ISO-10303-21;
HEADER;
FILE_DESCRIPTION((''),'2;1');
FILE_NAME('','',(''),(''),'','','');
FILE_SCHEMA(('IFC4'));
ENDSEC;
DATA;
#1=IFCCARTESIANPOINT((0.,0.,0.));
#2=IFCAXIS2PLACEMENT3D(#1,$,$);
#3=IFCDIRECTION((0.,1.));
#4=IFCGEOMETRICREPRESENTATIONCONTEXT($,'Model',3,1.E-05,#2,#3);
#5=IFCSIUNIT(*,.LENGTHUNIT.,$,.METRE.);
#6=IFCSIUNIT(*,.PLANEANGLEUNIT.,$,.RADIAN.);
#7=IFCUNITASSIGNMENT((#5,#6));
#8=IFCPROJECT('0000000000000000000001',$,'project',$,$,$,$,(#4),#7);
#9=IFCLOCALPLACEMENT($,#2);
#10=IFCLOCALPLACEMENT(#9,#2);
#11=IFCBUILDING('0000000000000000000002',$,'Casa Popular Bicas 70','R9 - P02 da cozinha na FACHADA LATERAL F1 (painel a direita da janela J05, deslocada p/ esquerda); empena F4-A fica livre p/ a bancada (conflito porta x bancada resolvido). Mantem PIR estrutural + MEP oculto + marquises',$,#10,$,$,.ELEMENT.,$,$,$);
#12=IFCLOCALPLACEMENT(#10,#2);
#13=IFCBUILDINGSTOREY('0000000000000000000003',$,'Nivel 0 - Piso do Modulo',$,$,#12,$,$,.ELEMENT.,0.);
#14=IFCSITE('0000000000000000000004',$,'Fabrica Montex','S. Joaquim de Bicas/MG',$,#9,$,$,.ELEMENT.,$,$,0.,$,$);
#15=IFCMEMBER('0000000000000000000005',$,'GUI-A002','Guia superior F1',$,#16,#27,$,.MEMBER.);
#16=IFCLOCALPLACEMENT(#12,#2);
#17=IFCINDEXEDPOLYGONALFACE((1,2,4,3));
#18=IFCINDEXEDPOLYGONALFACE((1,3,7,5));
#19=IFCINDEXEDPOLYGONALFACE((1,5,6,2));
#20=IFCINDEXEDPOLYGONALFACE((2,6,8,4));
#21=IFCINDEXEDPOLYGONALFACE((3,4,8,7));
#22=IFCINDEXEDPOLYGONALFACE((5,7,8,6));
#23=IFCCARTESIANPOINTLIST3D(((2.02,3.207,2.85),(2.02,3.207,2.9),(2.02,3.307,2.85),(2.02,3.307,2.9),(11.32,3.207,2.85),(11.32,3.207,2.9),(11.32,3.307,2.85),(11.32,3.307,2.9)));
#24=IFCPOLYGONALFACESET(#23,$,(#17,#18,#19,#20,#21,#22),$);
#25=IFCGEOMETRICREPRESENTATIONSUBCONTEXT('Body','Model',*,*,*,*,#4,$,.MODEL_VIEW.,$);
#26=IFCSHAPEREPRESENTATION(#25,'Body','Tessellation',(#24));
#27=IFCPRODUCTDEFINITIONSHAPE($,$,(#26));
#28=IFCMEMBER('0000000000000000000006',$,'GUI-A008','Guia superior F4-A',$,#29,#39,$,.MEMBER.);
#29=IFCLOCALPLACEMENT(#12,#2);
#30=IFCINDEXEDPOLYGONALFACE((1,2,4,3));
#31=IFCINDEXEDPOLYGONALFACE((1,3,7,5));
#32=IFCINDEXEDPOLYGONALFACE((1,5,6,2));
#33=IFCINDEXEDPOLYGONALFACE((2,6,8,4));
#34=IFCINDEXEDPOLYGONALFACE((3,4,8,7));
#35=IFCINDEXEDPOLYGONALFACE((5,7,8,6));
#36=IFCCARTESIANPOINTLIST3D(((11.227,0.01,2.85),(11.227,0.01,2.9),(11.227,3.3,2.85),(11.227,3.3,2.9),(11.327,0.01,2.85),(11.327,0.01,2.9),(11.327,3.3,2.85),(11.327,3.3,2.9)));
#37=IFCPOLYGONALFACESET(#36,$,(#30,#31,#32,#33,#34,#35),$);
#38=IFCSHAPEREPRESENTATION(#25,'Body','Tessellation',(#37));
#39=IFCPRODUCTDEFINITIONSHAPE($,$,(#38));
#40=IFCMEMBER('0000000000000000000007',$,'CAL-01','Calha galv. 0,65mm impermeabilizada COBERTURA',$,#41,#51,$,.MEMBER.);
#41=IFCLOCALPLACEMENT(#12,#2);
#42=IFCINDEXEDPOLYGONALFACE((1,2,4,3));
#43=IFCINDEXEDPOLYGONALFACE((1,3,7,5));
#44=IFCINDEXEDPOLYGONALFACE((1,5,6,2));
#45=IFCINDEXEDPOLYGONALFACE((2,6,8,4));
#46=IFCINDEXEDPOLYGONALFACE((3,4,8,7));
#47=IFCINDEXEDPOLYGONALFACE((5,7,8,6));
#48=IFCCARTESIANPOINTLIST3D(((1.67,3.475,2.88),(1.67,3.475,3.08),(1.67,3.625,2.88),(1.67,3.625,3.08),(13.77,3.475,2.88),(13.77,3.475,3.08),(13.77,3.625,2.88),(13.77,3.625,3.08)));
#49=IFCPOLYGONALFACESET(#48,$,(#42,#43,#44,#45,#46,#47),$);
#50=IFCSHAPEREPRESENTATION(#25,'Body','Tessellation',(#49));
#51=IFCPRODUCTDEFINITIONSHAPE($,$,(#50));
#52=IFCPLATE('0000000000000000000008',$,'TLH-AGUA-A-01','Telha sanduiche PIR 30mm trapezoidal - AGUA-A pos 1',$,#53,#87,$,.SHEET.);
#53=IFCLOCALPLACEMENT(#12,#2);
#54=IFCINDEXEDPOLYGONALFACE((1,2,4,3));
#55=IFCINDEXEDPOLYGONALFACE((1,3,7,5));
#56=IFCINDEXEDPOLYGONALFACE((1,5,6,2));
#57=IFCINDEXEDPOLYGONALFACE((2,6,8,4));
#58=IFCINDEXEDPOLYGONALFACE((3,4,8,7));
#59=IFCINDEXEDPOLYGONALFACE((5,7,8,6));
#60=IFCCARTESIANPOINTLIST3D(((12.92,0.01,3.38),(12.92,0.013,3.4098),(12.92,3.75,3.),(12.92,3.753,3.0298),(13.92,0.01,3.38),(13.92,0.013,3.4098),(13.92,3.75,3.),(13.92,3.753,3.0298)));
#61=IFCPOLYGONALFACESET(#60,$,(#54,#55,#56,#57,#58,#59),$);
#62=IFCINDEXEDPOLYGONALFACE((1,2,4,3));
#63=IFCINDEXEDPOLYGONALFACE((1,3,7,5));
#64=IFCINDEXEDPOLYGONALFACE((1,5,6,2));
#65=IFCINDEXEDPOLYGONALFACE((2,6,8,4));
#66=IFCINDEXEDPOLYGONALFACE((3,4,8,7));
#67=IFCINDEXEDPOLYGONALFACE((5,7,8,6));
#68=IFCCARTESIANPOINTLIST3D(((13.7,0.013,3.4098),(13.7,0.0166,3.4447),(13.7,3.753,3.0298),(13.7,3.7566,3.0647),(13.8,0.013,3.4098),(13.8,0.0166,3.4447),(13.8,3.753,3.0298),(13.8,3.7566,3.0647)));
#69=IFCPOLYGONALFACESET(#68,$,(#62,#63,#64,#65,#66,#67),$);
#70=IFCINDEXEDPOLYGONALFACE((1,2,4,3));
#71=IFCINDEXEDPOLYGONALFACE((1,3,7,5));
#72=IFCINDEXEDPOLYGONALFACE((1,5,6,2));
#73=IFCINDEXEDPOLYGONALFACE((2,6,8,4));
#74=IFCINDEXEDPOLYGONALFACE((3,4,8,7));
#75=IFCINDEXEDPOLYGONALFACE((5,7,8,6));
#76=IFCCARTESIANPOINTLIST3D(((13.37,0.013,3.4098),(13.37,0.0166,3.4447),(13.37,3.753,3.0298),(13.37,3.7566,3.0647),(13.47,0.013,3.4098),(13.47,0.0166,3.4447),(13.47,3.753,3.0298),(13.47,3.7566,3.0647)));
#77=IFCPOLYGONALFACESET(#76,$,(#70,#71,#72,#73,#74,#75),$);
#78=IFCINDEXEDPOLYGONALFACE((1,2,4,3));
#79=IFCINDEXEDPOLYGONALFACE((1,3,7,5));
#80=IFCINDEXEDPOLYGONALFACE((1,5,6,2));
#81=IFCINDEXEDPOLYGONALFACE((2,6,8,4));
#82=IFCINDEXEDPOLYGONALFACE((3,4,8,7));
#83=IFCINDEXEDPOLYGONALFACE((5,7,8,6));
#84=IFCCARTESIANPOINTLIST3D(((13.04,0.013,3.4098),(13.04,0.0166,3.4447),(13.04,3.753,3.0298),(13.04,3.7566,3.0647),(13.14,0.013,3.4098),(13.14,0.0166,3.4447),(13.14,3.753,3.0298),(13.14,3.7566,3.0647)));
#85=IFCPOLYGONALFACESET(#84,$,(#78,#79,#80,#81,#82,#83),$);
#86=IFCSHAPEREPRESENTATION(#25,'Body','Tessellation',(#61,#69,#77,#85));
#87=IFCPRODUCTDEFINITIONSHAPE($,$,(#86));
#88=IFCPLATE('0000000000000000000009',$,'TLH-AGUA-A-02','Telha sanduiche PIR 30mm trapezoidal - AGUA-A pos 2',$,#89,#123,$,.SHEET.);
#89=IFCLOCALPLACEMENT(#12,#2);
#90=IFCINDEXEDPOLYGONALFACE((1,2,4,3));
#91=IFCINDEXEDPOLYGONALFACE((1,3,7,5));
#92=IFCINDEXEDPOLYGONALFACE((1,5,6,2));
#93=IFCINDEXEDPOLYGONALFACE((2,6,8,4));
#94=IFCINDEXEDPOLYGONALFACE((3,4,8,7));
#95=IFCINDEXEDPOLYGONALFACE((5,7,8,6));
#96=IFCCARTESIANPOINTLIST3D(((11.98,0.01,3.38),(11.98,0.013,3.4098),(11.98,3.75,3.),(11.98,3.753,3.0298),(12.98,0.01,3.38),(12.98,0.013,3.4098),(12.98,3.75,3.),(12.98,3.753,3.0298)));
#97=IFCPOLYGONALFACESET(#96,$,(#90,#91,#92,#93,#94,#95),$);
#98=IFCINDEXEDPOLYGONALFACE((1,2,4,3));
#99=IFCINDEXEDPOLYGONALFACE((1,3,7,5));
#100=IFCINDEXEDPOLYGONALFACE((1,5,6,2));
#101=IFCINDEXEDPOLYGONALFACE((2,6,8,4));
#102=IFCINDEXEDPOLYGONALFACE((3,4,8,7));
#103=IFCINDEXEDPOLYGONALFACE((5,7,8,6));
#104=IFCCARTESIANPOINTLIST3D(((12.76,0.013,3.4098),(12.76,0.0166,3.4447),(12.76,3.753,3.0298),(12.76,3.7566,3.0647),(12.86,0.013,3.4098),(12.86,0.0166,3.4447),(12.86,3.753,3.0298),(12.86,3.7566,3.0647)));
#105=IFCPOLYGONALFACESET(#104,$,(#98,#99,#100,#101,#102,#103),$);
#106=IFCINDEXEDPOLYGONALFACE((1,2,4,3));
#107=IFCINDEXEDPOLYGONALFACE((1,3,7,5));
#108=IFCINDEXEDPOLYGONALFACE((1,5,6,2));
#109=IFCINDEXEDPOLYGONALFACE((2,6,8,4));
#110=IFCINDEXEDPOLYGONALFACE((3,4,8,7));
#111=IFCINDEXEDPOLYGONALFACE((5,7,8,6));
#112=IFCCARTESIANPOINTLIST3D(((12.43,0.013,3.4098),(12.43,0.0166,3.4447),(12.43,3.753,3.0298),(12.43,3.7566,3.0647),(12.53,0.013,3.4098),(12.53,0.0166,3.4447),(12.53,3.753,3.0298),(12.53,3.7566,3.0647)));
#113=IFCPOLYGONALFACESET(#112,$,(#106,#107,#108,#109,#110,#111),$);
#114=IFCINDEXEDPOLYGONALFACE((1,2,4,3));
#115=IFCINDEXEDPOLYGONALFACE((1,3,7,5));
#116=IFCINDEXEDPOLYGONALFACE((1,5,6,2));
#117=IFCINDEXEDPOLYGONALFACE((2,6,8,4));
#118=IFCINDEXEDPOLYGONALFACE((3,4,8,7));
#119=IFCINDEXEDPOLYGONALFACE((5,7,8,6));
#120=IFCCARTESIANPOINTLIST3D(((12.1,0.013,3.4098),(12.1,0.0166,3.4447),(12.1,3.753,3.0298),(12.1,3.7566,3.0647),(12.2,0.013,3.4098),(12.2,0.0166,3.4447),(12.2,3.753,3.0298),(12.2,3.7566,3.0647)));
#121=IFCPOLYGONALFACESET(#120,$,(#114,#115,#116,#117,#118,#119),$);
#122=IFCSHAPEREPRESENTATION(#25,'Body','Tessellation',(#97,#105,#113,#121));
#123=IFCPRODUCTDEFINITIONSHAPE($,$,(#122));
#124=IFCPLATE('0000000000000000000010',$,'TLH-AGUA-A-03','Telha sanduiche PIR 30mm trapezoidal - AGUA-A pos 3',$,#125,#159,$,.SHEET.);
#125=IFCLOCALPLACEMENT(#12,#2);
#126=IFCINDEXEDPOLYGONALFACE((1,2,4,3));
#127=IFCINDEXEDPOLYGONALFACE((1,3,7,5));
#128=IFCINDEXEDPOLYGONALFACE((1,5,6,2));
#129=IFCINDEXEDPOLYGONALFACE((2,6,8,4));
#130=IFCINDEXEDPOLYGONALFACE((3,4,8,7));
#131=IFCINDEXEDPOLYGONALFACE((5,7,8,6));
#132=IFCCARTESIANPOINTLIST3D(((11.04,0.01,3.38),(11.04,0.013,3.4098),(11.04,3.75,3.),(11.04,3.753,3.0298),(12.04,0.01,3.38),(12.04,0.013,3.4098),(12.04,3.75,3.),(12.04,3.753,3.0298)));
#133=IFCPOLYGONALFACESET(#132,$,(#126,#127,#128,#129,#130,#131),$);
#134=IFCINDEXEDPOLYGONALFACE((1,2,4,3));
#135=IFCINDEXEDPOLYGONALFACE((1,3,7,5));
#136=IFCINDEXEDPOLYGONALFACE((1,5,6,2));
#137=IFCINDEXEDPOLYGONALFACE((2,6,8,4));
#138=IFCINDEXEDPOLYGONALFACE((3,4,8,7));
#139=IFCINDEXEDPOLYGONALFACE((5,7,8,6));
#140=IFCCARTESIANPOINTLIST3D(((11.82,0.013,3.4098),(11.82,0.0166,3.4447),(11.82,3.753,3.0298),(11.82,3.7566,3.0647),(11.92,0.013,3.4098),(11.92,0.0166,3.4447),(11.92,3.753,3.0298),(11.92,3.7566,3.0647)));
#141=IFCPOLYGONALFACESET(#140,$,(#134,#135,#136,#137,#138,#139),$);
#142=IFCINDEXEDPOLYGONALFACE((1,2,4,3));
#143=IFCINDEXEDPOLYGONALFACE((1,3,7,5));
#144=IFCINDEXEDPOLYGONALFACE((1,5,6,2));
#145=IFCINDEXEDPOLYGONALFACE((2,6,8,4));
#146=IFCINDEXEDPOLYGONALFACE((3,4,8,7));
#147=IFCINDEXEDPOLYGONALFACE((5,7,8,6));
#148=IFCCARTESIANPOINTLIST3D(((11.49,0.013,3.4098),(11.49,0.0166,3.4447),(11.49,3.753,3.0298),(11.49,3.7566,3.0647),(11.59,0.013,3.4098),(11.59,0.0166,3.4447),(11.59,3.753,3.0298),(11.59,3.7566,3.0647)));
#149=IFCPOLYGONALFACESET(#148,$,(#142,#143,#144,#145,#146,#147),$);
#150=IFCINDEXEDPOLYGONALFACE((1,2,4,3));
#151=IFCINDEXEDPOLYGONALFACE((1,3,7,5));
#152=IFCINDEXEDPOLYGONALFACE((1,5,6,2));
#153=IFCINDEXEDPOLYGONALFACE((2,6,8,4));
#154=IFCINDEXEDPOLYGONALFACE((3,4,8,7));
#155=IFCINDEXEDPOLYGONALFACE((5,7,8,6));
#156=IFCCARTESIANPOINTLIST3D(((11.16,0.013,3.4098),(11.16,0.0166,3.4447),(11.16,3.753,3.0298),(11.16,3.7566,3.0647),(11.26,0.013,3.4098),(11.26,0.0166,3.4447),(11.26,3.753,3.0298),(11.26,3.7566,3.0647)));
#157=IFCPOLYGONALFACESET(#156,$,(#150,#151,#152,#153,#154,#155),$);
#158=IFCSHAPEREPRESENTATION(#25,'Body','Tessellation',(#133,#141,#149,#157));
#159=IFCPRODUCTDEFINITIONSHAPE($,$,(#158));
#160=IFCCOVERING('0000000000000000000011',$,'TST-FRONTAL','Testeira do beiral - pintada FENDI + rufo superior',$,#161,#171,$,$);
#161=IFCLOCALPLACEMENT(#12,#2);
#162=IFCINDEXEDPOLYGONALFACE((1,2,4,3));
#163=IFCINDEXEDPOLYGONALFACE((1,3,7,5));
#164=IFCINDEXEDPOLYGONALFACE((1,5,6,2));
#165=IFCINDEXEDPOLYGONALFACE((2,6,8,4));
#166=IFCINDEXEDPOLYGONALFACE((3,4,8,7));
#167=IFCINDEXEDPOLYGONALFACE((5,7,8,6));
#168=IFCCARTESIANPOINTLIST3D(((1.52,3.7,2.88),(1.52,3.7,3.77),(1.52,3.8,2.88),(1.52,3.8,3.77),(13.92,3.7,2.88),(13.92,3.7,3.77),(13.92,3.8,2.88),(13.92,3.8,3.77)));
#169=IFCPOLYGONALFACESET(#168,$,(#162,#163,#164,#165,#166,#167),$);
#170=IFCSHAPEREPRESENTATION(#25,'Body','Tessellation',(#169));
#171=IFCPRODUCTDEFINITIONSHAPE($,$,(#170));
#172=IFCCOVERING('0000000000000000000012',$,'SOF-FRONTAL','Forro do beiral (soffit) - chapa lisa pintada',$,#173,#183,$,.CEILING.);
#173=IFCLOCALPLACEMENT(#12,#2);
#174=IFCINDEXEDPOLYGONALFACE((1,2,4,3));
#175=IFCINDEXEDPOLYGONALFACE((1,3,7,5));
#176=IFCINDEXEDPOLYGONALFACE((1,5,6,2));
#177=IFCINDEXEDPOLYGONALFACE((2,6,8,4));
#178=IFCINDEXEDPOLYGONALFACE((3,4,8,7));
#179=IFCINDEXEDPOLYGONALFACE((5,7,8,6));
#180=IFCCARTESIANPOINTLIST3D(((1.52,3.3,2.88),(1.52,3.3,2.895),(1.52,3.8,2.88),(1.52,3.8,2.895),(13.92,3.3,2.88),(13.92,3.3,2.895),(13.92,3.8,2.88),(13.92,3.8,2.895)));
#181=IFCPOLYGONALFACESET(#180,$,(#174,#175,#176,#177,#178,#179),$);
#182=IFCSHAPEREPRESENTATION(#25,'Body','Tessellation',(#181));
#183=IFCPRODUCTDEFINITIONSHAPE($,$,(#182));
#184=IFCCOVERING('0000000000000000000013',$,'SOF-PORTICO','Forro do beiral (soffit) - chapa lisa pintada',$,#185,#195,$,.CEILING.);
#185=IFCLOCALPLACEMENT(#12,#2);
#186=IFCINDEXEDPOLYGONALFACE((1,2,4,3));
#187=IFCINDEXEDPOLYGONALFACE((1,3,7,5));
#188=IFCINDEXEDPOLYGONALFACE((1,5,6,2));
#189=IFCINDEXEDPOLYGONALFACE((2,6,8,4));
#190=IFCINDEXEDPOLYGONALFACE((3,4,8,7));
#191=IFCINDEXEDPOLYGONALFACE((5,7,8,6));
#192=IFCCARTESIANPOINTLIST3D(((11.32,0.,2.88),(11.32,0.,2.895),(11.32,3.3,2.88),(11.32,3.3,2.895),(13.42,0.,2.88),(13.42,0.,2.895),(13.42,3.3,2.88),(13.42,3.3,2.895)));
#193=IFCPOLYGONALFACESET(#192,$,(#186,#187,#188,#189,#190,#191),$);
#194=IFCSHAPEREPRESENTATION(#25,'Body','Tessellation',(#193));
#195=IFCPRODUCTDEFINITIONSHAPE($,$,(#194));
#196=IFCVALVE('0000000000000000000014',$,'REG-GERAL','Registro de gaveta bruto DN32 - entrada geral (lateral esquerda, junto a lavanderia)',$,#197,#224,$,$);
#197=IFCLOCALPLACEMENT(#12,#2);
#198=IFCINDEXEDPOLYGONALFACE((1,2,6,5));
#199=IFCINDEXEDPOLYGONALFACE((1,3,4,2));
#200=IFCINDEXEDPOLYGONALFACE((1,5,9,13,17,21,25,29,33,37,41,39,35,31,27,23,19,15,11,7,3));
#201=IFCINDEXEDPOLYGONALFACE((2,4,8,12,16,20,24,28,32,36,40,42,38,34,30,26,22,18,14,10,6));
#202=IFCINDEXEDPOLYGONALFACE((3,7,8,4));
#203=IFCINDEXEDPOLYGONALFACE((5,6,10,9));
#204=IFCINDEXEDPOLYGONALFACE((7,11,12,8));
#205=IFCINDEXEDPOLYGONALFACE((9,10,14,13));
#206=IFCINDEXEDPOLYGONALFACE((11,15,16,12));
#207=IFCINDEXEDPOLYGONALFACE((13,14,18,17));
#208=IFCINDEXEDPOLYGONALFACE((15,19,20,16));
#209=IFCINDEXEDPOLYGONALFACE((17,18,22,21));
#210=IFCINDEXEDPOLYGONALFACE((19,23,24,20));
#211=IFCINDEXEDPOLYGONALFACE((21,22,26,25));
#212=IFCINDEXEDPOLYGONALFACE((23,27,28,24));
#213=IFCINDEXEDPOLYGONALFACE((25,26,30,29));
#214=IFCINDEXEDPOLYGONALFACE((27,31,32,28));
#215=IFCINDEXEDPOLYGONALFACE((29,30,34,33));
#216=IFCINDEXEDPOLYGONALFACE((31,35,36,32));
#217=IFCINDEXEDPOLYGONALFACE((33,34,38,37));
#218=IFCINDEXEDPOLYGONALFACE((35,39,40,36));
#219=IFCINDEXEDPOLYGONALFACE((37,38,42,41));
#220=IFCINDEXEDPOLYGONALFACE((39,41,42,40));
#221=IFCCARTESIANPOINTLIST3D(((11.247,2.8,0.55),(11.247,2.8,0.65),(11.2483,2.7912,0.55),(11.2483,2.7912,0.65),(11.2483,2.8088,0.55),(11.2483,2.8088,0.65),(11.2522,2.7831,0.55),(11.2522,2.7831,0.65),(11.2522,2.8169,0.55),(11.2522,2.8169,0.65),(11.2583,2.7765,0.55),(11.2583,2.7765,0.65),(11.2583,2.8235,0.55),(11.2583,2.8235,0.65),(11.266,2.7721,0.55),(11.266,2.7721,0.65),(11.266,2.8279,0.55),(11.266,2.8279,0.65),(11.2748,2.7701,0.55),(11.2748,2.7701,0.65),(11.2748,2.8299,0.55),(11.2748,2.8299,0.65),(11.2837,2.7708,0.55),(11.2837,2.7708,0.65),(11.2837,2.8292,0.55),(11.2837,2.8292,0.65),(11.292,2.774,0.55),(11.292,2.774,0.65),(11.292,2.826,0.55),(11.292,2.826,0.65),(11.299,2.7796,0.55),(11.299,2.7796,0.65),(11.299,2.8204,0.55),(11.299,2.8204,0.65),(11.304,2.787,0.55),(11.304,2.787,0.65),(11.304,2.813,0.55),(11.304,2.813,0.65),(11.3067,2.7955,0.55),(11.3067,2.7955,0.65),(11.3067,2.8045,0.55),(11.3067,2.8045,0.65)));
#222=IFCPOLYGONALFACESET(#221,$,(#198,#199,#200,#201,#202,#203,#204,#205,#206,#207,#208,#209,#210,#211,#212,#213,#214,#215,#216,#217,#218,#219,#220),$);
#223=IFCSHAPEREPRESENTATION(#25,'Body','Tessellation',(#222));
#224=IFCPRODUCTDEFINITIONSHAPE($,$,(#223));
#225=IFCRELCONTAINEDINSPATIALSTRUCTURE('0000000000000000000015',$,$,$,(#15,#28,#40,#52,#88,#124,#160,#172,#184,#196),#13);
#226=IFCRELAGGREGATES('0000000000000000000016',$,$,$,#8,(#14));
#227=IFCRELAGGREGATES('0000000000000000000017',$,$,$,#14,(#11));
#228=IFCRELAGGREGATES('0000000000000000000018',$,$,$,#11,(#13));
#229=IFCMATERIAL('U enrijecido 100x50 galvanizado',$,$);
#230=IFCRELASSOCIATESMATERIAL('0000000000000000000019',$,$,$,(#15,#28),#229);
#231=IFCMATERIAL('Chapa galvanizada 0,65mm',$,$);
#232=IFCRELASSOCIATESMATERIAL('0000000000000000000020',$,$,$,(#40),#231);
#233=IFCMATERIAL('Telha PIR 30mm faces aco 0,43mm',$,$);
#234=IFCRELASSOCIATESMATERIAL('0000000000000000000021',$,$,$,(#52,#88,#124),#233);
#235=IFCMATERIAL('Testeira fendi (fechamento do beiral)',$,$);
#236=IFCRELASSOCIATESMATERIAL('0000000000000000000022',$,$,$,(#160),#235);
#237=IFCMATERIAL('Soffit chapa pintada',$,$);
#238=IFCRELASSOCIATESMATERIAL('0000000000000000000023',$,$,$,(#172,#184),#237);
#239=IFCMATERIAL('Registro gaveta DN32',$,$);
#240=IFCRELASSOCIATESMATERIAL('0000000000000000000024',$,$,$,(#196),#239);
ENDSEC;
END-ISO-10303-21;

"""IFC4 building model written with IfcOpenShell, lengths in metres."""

from ifc_helpers import new_model, si_unit, direction, frame, frame_2d, origin, origin_2d, place, context, subcontext, project, spatial, rectangle, circle, extrude, material, element, save


model = new_model("IFC4")

# Units and contexts
model_context = context("Model", 3, precision=1e-05, world=origin(), true_north=direction((0.0, 1.0)))
body_context = subcontext(model_context, "Body", "Model", "MODEL_VIEW")
ifc_project = project(units=[si_unit("LENGTHUNIT", "METRE"), si_unit("PLANEANGLEUNIT", "RADIAN")], contexts=[model_context])

# Site, building, storey
site_placement = place(None, origin())
site = spatial("IfcSite", under=ifc_project, at=site_placement, Name="Fabrica Montex", Description="S. Joaquim de Bicas/MG", CompositionType="ELEMENT", RefElevation=0.0)
building_placement = place(site_placement, origin())
building = spatial("IfcBuilding", under=site, at=building_placement, Name="Casa Popular Bicas 70", Description="R9 - P02 da cozinha na FACHADA LATERAL F1 (painel a direita da janela J05, deslocada p/ esquerda); empena F4-A fica livre p/ a bancada (conflito porta x bancada resolvido). Mantem PIR estrutural + MEP oculto + marquises", CompositionType="ELEMENT")
storey_placement = place(building_placement, origin())
storey = spatial("IfcBuildingStorey", under=building, at=storey_placement, Name="Nivel 0 - Piso do Modulo", CompositionType="ELEMENT", Elevation=0.0)

# Members
ifc_material_1 = material(Name="U enrijecido 100x50 galvanizado")
member_1_placement = place(None, frame((11.32, 3.257, 2.875), z_axis=(-1.0, 0.0, 0.0), x_axis=(0.0, 0.0, 1.0)))
element("IfcMember", 1, at=member_1_placement, inside=storey, material=ifc_material_1, Name="GUI-A002", Description="Guia superior F1", PredefinedType="MEMBER", context=body_context, shape_type="SweptSolid", body=[
    extrude(rectangle(XDim=0.05, YDim=0.1, at=origin_2d()), origin(), (0.0, 0.0, 1.0), 9.3),
])
member_2_placement = place(None, frame((11.277, 3.3, 2.875), z_axis=(0.0, -1.0, 0.0), x_axis=(0.0, 0.0, 1.0)))
element("IfcMember", 2, at=member_2_placement, inside=storey, material=ifc_material_1, Name="GUI-A008", Description="Guia superior F4-A", PredefinedType="MEMBER", context=body_context, shape_type="SweptSolid", body=[
    extrude(rectangle(XDim=0.05, YDim=0.1, at=origin_2d()), origin(), (0.0, 0.0, 1.0), 3.29),
])
ifc_material_2 = material(Name="Chapa galvanizada 0,65mm")
member_3_placement = place(None, frame((13.77, 3.55, 2.98), z_axis=(-1.0, 0.0, 0.0), x_axis=(0.0, 0.0, 1.0)))
element("IfcMember", 3, at=member_3_placement, inside=storey, material=ifc_material_2, Name="CAL-01", Description="Calha galv. 0,65mm impermeabilizada COBERTURA", PredefinedType="MEMBER", context=body_context, shape_type="SweptSolid", body=[
    extrude(rectangle(XDim=0.2, YDim=0.15, at=origin_2d()), origin(), (0.0, 0.0, 1.0), 12.1),
])

# Plates
ifc_material_3 = material(Name="Telha PIR 30mm faces aco 0,43mm")
for number, where, z_axis, x_axis, name, description in (
    (4, (13.92, 3.75, 3.0), (0.0, 0.101084, 0.994878), (-1.0, 0.0, 0.0), "TLH-AGUA-A-01", "Telha sanduiche PIR 30mm trapezoidal - AGUA-A pos 1"),
    (5, (12.98, 3.75, 3.0), (0.0, 0.101084, 0.994878), (-1.0, 0.0, 0.0), "TLH-AGUA-A-02", "Telha sanduiche PIR 30mm trapezoidal - AGUA-A pos 2"),
    (6, (12.04, 3.75, 3.0), (0.0, 0.101084, 0.994878), (-1.0, 0.0, 0.0), "TLH-AGUA-A-03", "Telha sanduiche PIR 30mm trapezoidal - AGUA-A pos 3"),
):
    element("IfcPlate", number, at=place(None, frame(where, z_axis=z_axis, x_axis=x_axis)), inside=storey, material=ifc_material_3, Name=name, Description=description, PredefinedType="SHEET", context=body_context, shape_type="SweptSolid", body=[
        extrude(rectangle(XDim=1.0, YDim=3.7593, at=frame_2d((0.5, 1.8796))), origin(), (0.0, 0.0, 1.0), 0.03),
        extrude(rectangle(XDim=0.1, YDim=3.7593, at=frame_2d((0.17, 1.8796))), frame((0.0, 0.0, 0.03)), (0.0, 0.0, 1.0), 0.035),
        extrude(rectangle(XDim=0.1, YDim=3.7593, at=frame_2d((0.5, 1.8796))), frame((0.0, 0.0, 0.03)), (0.0, 0.0, 1.0), 0.035),
        extrude(rectangle(XDim=0.1, YDim=3.7593, at=frame_2d((0.83, 1.8796))), frame((0.0, 0.0, 0.03)), (0.0, 0.0, 1.0), 0.035),
    ])

# Coverings
ifc_material_4 = material(Name="Testeira fendi (fechamento do beiral)")
covering_1_placement = place(None, frame((13.92, 3.75, 2.88), z_axis=(0.0, 0.0, 1.0), x_axis=(-1.0, 0.0, 0.0)))
element("IfcCovering", 7, at=covering_1_placement, inside=storey, material=ifc_material_4, Name="TST-FRONTAL", Description="Testeira do beiral - pintada FENDI + rufo superior", context=body_context, shape_type="SweptSolid", body=[
    extrude(rectangle(XDim=12.4, YDim=0.1, at=frame_2d((6.2, 0.0))), origin(), (0.0, 0.0, 1.0), 0.89),
])
ifc_material_5 = material(Name="Soffit chapa pintada")
covering_2_placement = place(None, frame((13.92, 3.8, 2.88), z_axis=(0.0, 0.0, 1.0), x_axis=(-1.0, 0.0, 0.0)))
element("IfcCovering", 8, at=covering_2_placement, inside=storey, material=ifc_material_5, Name="SOF-FRONTAL", Description="Forro do beiral (soffit) - chapa lisa pintada", PredefinedType="CEILING", context=body_context, shape_type="SweptSolid", body=[
    extrude(rectangle(XDim=12.4, YDim=0.5, at=frame_2d((6.2, 0.25))), origin(), (0.0, 0.0, 1.0), 0.015),
])
covering_3_placement = place(None, frame((13.42, 3.3, 2.88), z_axis=(0.0, 0.0, 1.0), x_axis=(-1.0, 0.0, 0.0)))
element("IfcCovering", 9, at=covering_3_placement, inside=storey, material=ifc_material_5, Name="SOF-PORTICO", Description="Forro do beiral (soffit) - chapa lisa pintada", PredefinedType="CEILING", context=body_context, shape_type="SweptSolid", body=[
    extrude(rectangle(XDim=2.1, YDim=3.3, at=frame_2d((1.05, 1.65))), origin(), (0.0, 0.0, 1.0), 0.015),
])

# Valve
ifc_material_6 = material(Name="Registro gaveta DN32")
valve_placement = place(None, frame((11.277, 2.8, 0.55), z_axis=(0.0, 0.0, 1.0), x_axis=(-1.0, 0.0, 0.0)))
element("IfcValve", 10, at=valve_placement, inside=storey, material=ifc_material_6, Name="REG-GERAL", Description="Registro de gaveta bruto DN32 - entrada geral (lateral esquerda, junto a lavanderia)", context=body_context, shape_type="SweptSolid", body=[
    extrude(circle(Radius=0.03, at=origin_2d()), origin(), (0.0, 0.0, 1.0), 0.1),
])

save(model, "model.ifc")
